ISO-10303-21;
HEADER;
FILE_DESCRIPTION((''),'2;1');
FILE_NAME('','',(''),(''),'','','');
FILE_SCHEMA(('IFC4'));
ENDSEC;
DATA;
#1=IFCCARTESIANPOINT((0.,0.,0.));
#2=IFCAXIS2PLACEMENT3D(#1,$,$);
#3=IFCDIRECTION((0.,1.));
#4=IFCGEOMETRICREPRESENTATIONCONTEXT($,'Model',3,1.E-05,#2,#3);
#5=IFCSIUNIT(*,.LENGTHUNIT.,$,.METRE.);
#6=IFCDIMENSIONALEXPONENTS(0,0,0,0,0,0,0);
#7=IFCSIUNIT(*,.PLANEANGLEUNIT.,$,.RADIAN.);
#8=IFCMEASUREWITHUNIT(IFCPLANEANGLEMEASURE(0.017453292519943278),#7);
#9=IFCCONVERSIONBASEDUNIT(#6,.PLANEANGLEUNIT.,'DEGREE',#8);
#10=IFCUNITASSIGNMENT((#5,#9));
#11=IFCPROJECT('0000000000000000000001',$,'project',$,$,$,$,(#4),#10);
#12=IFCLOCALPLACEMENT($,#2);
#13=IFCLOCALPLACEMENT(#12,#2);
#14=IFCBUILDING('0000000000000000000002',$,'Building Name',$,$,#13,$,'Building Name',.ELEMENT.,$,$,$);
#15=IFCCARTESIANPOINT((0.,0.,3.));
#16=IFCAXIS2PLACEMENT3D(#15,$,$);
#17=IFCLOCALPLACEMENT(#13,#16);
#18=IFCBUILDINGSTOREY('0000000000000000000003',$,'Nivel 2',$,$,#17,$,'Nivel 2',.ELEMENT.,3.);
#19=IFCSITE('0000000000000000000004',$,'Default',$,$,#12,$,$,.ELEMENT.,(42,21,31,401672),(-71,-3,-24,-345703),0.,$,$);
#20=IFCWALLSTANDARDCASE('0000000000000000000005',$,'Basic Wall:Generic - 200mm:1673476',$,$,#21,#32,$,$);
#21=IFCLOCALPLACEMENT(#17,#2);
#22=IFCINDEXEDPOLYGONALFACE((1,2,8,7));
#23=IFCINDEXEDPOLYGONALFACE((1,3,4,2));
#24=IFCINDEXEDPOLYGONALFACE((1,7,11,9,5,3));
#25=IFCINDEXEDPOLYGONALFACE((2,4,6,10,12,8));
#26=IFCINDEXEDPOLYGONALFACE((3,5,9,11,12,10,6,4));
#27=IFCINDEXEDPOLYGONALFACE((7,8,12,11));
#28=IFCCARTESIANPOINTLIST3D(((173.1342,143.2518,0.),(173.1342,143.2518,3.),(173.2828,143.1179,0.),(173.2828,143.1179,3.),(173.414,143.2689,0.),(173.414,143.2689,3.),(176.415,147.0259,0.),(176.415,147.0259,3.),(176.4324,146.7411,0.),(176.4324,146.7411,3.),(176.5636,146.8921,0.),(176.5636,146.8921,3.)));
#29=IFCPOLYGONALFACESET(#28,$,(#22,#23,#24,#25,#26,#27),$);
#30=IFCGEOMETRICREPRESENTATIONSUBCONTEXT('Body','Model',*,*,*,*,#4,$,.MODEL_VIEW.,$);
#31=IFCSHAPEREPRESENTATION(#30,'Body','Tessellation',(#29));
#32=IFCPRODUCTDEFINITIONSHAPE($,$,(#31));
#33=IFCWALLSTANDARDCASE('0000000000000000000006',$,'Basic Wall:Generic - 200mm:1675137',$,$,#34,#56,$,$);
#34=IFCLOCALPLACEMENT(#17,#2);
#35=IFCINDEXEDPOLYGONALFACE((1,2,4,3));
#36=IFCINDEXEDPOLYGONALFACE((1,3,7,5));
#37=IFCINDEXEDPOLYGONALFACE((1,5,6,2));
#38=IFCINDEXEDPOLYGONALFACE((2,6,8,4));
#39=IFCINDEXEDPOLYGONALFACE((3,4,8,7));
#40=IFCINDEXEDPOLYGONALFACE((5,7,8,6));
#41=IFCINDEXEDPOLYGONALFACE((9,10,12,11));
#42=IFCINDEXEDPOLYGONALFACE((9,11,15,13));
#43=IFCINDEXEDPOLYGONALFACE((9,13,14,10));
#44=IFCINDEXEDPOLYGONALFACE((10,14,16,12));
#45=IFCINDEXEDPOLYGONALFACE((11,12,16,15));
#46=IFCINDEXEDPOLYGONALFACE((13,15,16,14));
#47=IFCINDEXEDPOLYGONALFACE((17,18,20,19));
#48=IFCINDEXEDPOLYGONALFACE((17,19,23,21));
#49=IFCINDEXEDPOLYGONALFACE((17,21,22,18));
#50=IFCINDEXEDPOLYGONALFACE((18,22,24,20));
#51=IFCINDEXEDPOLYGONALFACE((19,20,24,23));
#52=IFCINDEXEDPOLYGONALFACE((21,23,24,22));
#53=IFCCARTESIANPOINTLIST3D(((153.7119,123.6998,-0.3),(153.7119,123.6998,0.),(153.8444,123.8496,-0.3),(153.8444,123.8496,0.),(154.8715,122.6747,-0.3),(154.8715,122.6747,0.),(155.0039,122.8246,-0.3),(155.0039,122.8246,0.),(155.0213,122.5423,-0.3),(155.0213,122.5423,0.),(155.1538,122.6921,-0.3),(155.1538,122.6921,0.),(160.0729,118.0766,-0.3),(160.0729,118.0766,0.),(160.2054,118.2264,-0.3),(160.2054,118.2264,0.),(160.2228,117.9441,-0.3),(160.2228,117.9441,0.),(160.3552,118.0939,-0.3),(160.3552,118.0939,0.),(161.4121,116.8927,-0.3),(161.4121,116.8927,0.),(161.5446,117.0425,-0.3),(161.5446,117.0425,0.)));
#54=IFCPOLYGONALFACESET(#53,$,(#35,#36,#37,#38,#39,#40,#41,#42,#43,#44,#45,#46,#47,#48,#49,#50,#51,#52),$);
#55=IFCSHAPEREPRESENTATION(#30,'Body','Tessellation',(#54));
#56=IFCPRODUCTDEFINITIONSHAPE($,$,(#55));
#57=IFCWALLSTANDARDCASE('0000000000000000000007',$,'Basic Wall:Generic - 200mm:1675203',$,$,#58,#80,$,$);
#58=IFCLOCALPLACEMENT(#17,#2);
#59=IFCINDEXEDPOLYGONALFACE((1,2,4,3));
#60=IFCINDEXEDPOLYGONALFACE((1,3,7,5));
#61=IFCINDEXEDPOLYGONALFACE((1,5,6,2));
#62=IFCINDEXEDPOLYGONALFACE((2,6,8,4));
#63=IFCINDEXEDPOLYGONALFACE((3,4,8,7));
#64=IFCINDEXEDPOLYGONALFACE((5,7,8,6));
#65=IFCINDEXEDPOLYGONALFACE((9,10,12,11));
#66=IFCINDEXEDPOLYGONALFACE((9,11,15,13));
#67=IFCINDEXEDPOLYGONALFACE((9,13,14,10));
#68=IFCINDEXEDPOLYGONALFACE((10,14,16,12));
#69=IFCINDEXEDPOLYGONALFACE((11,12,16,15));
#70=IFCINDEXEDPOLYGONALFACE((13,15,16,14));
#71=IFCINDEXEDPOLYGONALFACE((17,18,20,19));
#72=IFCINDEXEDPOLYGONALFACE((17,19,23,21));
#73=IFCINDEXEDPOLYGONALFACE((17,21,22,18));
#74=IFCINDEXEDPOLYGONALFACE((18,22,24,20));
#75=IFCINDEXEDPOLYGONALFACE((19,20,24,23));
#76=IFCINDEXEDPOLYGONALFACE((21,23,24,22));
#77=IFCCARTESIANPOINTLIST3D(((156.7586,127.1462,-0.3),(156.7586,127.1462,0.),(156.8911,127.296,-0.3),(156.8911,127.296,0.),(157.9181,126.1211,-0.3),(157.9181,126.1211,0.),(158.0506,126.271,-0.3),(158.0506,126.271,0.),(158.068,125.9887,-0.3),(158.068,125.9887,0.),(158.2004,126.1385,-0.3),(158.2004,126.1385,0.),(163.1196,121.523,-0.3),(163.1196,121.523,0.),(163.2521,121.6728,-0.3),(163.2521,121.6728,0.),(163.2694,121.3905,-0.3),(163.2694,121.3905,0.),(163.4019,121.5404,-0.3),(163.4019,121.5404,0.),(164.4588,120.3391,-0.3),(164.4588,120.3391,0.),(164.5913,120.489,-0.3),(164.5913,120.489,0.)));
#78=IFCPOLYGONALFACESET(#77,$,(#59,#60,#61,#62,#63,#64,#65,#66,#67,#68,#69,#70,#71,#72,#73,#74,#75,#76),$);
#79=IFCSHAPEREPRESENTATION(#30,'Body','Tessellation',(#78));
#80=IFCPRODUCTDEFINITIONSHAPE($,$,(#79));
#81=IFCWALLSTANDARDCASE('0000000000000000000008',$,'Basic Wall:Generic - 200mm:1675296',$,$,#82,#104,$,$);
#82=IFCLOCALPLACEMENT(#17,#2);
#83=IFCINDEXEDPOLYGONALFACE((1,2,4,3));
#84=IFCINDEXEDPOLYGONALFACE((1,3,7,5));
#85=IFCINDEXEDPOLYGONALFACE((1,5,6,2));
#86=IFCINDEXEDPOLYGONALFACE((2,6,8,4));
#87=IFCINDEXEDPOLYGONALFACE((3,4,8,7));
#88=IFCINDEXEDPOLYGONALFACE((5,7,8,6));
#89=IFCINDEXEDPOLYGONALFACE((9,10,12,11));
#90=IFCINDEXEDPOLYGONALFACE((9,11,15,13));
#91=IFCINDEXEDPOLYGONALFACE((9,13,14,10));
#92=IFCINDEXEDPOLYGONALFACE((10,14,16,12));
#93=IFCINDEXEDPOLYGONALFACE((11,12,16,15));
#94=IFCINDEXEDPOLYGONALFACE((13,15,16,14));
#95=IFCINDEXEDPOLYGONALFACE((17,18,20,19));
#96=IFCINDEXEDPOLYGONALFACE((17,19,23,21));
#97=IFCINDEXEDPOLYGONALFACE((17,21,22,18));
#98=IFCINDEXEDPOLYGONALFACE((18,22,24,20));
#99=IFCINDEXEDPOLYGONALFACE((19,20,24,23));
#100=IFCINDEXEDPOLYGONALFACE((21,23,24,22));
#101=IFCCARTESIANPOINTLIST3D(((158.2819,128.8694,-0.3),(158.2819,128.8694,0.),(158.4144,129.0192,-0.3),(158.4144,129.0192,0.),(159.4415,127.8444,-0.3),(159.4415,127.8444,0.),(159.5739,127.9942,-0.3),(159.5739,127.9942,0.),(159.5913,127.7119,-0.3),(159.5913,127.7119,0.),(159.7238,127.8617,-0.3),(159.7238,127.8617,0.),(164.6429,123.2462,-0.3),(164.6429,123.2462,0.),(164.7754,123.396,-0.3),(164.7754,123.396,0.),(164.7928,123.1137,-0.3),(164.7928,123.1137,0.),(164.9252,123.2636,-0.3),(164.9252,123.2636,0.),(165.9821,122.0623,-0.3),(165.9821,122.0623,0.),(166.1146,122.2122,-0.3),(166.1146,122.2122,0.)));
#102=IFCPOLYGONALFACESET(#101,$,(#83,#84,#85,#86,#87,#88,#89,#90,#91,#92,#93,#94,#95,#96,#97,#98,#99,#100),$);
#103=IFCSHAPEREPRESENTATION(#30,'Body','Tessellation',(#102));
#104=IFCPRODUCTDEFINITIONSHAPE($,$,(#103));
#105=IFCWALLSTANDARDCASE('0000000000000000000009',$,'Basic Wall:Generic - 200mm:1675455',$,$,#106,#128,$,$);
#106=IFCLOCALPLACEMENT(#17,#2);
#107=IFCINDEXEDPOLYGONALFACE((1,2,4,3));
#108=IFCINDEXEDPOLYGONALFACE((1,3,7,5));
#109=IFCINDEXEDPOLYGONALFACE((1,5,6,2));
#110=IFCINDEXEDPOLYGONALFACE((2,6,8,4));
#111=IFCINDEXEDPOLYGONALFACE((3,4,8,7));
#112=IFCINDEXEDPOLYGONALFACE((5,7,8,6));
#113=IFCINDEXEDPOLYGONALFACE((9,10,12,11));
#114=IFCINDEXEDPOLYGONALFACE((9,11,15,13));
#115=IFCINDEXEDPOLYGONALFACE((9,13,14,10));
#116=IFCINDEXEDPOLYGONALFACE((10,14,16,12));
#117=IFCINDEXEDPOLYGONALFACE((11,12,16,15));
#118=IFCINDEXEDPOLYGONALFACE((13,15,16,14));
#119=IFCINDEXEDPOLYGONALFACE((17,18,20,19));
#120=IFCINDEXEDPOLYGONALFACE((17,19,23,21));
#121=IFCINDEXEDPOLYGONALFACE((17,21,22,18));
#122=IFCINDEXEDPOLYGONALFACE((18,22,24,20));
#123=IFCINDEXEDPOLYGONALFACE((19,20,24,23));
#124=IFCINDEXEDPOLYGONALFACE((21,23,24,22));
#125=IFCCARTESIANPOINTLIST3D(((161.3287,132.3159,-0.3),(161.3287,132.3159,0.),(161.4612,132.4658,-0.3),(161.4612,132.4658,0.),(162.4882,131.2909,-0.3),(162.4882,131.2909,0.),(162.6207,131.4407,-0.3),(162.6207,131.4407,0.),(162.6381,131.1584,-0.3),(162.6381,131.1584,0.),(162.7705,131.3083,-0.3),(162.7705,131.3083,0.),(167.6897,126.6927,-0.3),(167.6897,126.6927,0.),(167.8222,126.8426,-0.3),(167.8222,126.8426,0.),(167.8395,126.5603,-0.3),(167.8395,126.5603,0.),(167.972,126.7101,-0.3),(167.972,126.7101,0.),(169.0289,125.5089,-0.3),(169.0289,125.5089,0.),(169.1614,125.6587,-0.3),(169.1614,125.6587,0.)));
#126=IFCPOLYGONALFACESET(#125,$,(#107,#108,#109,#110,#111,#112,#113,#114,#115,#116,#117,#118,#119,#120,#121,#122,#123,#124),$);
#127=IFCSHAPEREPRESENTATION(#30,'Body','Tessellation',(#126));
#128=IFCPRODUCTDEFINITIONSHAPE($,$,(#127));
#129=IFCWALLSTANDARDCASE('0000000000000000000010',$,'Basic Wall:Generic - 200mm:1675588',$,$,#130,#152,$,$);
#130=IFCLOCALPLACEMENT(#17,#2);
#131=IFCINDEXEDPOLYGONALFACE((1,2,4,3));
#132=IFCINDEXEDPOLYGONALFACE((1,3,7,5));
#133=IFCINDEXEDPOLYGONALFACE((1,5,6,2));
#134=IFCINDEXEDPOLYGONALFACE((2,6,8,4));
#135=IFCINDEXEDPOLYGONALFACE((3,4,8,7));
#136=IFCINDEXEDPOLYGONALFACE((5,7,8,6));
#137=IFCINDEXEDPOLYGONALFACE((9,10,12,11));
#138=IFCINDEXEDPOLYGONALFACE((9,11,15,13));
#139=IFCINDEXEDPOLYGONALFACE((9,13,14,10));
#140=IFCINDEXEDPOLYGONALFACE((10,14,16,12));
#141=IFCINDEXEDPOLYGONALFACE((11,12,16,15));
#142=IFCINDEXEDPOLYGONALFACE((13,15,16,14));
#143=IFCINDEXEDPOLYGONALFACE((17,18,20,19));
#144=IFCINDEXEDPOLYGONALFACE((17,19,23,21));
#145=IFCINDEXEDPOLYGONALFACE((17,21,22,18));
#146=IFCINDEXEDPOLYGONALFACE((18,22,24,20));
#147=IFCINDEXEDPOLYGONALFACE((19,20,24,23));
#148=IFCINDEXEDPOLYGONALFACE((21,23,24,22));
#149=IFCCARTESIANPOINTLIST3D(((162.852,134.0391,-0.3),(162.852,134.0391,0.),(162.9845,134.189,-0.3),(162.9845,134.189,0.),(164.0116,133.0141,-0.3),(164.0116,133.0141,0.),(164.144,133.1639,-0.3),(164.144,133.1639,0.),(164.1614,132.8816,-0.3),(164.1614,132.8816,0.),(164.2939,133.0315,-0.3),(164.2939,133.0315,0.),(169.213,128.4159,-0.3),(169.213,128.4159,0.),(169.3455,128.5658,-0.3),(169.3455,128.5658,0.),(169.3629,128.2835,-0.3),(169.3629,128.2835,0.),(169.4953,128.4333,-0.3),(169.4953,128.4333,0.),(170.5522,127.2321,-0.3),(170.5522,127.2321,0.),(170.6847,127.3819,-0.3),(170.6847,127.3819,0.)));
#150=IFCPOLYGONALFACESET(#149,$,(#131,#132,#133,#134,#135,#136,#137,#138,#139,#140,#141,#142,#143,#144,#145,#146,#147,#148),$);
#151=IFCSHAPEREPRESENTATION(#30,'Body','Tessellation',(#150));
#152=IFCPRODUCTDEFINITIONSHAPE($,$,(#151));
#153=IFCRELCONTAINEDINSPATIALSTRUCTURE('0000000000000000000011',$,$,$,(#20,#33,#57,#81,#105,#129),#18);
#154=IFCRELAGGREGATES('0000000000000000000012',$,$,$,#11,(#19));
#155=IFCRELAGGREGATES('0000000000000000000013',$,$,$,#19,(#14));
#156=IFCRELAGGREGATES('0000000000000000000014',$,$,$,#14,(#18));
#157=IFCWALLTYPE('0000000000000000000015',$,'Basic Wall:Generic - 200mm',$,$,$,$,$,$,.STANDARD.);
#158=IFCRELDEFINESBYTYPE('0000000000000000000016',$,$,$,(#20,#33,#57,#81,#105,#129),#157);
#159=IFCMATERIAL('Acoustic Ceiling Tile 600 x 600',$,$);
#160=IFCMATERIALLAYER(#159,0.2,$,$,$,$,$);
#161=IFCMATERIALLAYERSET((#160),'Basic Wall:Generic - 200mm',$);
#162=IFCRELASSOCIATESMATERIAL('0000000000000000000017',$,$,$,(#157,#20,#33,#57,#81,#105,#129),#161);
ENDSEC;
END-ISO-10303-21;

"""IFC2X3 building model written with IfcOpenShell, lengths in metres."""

from ifc_helpers import new_model, entity, si_unit, converted_unit, direction, frame, frame_2d, origin, origin_2d_with_axis, place, context, subcontext, project, spatial, polyline, rectangle, outline, extrude, material, layer, layer_set, layer_usage, type_object, element, save


model = new_model("IFC2X3")

# Units and contexts
model_context = context("Model", 3, precision=1e-05, world=origin(), true_north=direction((0.0, 1.0)))
body_context = subcontext(model_context, "Body", "Model", "MODEL_VIEW")
ifc_project = project(units=[si_unit("LENGTHUNIT", "METRE"), converted_unit("PLANEANGLEUNIT", "DEGREE", entity("IfcPlaneAngleMeasure", 0.017453292519943278), si_unit("PLANEANGLEUNIT", "RADIAN"), dimensions=[0, 0, 0, 0, 0, 0, 0])], contexts=[model_context])

# Site, building, storey
site_placement = place(None, origin())
site = spatial("IfcSite", under=ifc_project, at=site_placement, Name="Default", CompositionType="ELEMENT", RefLatitude=(42, 21, 31, 401672), RefLongitude=(-71, -3, -24, -345703), RefElevation=0.0)
building_placement = place(site_placement, origin())
building = spatial("IfcBuilding", under=site, at=building_placement, Name="Building Name", LongName="Building Name", CompositionType="ELEMENT")
storey_placement = place(building_placement, frame((0.0, 0.0, 3.0)))
storey = spatial("IfcBuildingStorey", under=building, at=storey_placement, Name="Nivel 2", LongName="Nivel 2", CompositionType="ELEMENT", Elevation=3.0)

# Wall
ifc_material_1 = material(Name="Acoustic Ceiling Tile 600 x 600")
ifc_layer = layer(ifc_material_1, 0.2)
ifc_layer_set = layer_set([ifc_layer], Name="Basic Wall:Generic - 200mm")
ifc_layer_usage_1 = layer_usage(ifc_layer_set, "AXIS2", "NEGATIVE", 0.1)
wall_type_1 = type_object("IfcWallType", Name="Basic Wall:Generic - 200mm", PredefinedType="STANDARD", material=ifc_layer_set)
wall_1_placement = place(storey_placement, frame((173.2073, 143.1835, 0.0), z_axis=(0.0, 0.0, 1.0), x_axis=(0.656059, 0.75471, 0.0)))
element("IfcWallStandardCase", 1, at=wall_1_placement, inside=storey, type_object=wall_type_1, material=ifc_layer_usage_1, Name="Basic Wall:Generic - 200mm:1673476", context=body_context, shape_type="SweptSolid", body=[
    extrude(outline(polyline([(5.0008, -0.1), (5.0043, 0.1), (0.0035, 0.1), (0.0, -0.1), (0.2, -0.1), (4.8007, -0.1), (5.0008, -0.1)])), origin(), (0.0, 0.0, 1.0), 3.0),
])

# Walls, openings
ifc_layer_usage_2 = layer_usage(ifc_layer_set, "AXIS2", "NEGATIVE", 0.1)
wall_2_placement = place(storey_placement, frame((161.4784, 116.9676, -0.3), z_axis=(0.0, 0.0, 1.0), x_axis=(-0.749221, 0.66232, 0.0)))
wall_2 = element("IfcWallStandardCase", 2, at=wall_2_placement, inside=storey, type_object=wall_type_1, material=ifc_layer_usage_2, Name="Basic Wall:Generic - 200mm:1675137", context=body_context, shape_type="SweptSolid", body=[
    extrude(rectangle(XDim=10.2776, YDim=0.2, at=frame_2d((5.1388, 0.0), x_axis=(-1.0, 0.0))), origin(), (0.0, 0.0, 1.0), 0.3),
])
opening_1_placement = place(storey_placement, frame((161.4784, 116.9676, -0.3), z_axis=(0.0, 0.0, 1.0), x_axis=(-0.749221, 0.66232, 0.0)))
element("IfcOpeningElement", 3, at=opening_1_placement, cuts=wall_2, ObjectType="Opening", context=body_context, shape_type="SweptSolid", body=[
    extrude(rectangle(XDim=0.3, YDim=0.2, at=frame_2d((0.0, 0.0), x_axis=(1.0, 0.0))), frame((1.5874, 0.0, 0.15), z_axis=(1.0, 0.0, 0.0), x_axis=(0.0, 0.0, -1.0)), (0.0, 0.0, 1.0), 0.2),
])
opening_2_placement = place(storey_placement, frame((161.4784, 116.9676, -0.3), z_axis=(0.0, 0.0, 1.0), x_axis=(-0.749221, 0.66232, 0.0)))
element("IfcOpeningElement", 4, at=opening_2_placement, cuts=wall_2, ObjectType="Opening", context=body_context, shape_type="SweptSolid", body=[
    extrude(rectangle(XDim=0.3, YDim=0.2, at=frame_2d((0.0, 0.0), x_axis=(1.0, 0.0))), frame((8.53, 0.0, 0.15), z_axis=(1.0, 0.0, 0.0), x_axis=(0.0, 0.0, -1.0)), (0.0, 0.0, 1.0), 0.2),
])
ifc_layer_usage_3 = layer_usage(ifc_layer_set, "AXIS2", "NEGATIVE", 0.1)
wall_3_placement = place(storey_placement, frame((164.525, 120.414, -0.3), z_axis=(0.0, 0.0, 1.0), x_axis=(-0.749221, 0.66232, 0.0)))
wall_3 = element("IfcWallStandardCase", 5, at=wall_3_placement, inside=storey, type_object=wall_type_1, material=ifc_layer_usage_3, Name="Basic Wall:Generic - 200mm:1675203", context=body_context, shape_type="SweptSolid", body=[
    extrude(rectangle(XDim=10.2776, YDim=0.2, at=frame_2d((5.1388, 0.0), x_axis=(-1.0, 0.0))), origin(), (0.0, 0.0, 1.0), 0.3),
])
opening_3_placement = place(storey_placement, frame((164.525, 120.414, -0.3), z_axis=(0.0, 0.0, 1.0), x_axis=(-0.749221, 0.66232, 0.0)))
element("IfcOpeningElement", 6, at=opening_3_placement, cuts=wall_3, ObjectType="Opening", context=body_context, shape_type="SweptSolid", body=[
    extrude(rectangle(XDim=0.3, YDim=0.2, at=frame_2d((0.0, 0.0), x_axis=(1.0, 0.0))), frame((1.5874, 0.0, 0.15), z_axis=(1.0, 0.0, 0.0), x_axis=(0.0, 0.0, -1.0)), (0.0, 0.0, 1.0), 0.2),
])
opening_4_placement = place(storey_placement, frame((164.525, 120.414, -0.3), z_axis=(0.0, 0.0, 1.0), x_axis=(-0.749221, 0.66232, 0.0)))
element("IfcOpeningElement", 7, at=opening_4_placement, cuts=wall_3, ObjectType="Opening", context=body_context, shape_type="SweptSolid", body=[
    extrude(rectangle(XDim=0.3, YDim=0.2, at=frame_2d((0.0, 0.0), x_axis=(1.0, 0.0))), frame((8.53, 0.0, 0.15), z_axis=(1.0, 0.0, 0.0), x_axis=(0.0, 0.0, -1.0)), (0.0, 0.0, 1.0), 0.2),
])
ifc_layer_usage_4 = layer_usage(ifc_layer_set, "AXIS2", "NEGATIVE", 0.1)
wall_4_placement = place(storey_placement, frame((166.0484, 122.1373, -0.3), z_axis=(0.0, 0.0, 1.0), x_axis=(-0.749221, 0.66232, 0.0)))
wall_4 = element("IfcWallStandardCase", 8, at=wall_4_placement, inside=storey, type_object=wall_type_1, material=ifc_layer_usage_4, Name="Basic Wall:Generic - 200mm:1675296", context=body_context, shape_type="SweptSolid", body=[
    extrude(rectangle(XDim=10.2776, YDim=0.2, at=frame_2d((5.1388, 0.0), x_axis=(-1.0, 0.0))), origin(), (0.0, 0.0, 1.0), 0.3),
])
opening_5_placement = place(storey_placement, frame((166.0484, 122.1373, -0.3), z_axis=(0.0, 0.0, 1.0), x_axis=(-0.749221, 0.66232, 0.0)))
element("IfcOpeningElement", 9, at=opening_5_placement, cuts=wall_4, ObjectType="Opening", context=body_context, shape_type="SweptSolid", body=[
    extrude(rectangle(XDim=0.3, YDim=0.2, at=frame_2d((0.0, 0.0), x_axis=(1.0, 0.0))), frame((1.5874, 0.0, 0.15), z_axis=(1.0, 0.0, 0.0), x_axis=(0.0, 0.0, -1.0)), (0.0, 0.0, 1.0), 0.2),
])
opening_6_placement = place(storey_placement, frame((166.0484, 122.1373, -0.3), z_axis=(0.0, 0.0, 1.0), x_axis=(-0.749221, 0.66232, 0.0)))
element("IfcOpeningElement", 10, at=opening_6_placement, cuts=wall_4, ObjectType="Opening", context=body_context, shape_type="SweptSolid", body=[
    extrude(rectangle(XDim=0.3, YDim=0.2, at=origin_2d_with_axis()), frame((8.53, 0.0, 0.15), z_axis=(1.0, 0.0, 0.0), x_axis=(0.0, 0.0, -1.0)), (0.0, 0.0, 1.0), 0.2),
])
ifc_layer_usage_5 = layer_usage(ifc_layer_set, "AXIS2", "NEGATIVE", 0.1)
wall_5_placement = place(storey_placement, frame((169.0951, 125.5838, -0.3), z_axis=(0.0, 0.0, 1.0), x_axis=(-0.749221, 0.66232, 0.0)))
wall_5 = element("IfcWallStandardCase", 11, at=wall_5_placement, inside=storey, type_object=wall_type_1, material=ifc_layer_usage_5, Name="Basic Wall:Generic - 200mm:1675455", context=body_context, shape_type="SweptSolid", body=[
    extrude(rectangle(XDim=10.2776, YDim=0.2, at=frame_2d((5.1388, 0.0), x_axis=(-1.0, 0.0))), origin(), (0.0, 0.0, 1.0), 0.3),
])
opening_7_placement = place(storey_placement, frame((169.0951, 125.5838, -0.3), z_axis=(0.0, 0.0, 1.0), x_axis=(-0.749221, 0.66232, 0.0)))
element("IfcOpeningElement", 12, at=opening_7_placement, cuts=wall_5, ObjectType="Opening", context=body_context, shape_type="SweptSolid", body=[
    extrude(rectangle(XDim=0.3, YDim=0.2, at=frame_2d((0.0, 0.0), x_axis=(1.0, 0.0))), frame((1.5874, 0.0, 0.15), z_axis=(1.0, 0.0, 0.0), x_axis=(0.0, 0.0, -1.0)), (0.0, 0.0, 1.0), 0.2),
])
opening_8_placement = place(storey_placement, frame((169.0951, 125.5838, -0.3), z_axis=(0.0, 0.0, 1.0), x_axis=(-0.749221, 0.66232, 0.0)))
element("IfcOpeningElement", 13, at=opening_8_placement, cuts=wall_5, ObjectType="Opening", context=body_context, shape_type="SweptSolid", body=[
    extrude(rectangle(XDim=0.3, YDim=0.2, at=frame_2d((0.0, 0.0), x_axis=(1.0, 0.0))), frame((8.53, 0.0, 0.15), z_axis=(1.0, 0.0, 0.0), x_axis=(0.0, 0.0, -1.0)), (0.0, 0.0, 1.0), 0.2),
])
ifc_layer_usage_6 = layer_usage(ifc_layer_set, "AXIS2", "NEGATIVE", 0.1)
wall_6_placement = place(storey_placement, frame((170.6185, 127.307, -0.3), z_axis=(0.0, 0.0, 1.0), x_axis=(-0.749221, 0.66232, 0.0)))
wall_6 = element("IfcWallStandardCase", 14, at=wall_6_placement, inside=storey, type_object=wall_type_1, material=ifc_layer_usage_6, Name="Basic Wall:Generic - 200mm:1675588", context=body_context, shape_type="SweptSolid", body=[
    extrude(rectangle(XDim=10.2776, YDim=0.2, at=frame_2d((5.1388, 0.0), x_axis=(-1.0, 0.0))), origin(), (0.0, 0.0, 1.0), 0.3),
])
opening_9_placement = place(storey_placement, frame((170.6185, 127.307, -0.3), z_axis=(0.0, 0.0, 1.0), x_axis=(-0.749221, 0.66232, 0.0)))
element("IfcOpeningElement", 15, at=opening_9_placement, cuts=wall_6, ObjectType="Opening", context=body_context, shape_type="SweptSolid", body=[
    extrude(rectangle(XDim=0.3, YDim=0.2, at=origin_2d_with_axis()), frame((1.7874, 0.0, 0.15), z_axis=(-1.0, 0.0, 0.0), x_axis=(0.0, 0.0, 1.0)), (0.0, 0.0, 1.0), 0.2),
])
opening_10_placement = place(storey_placement, frame((170.6185, 127.307, -0.3), z_axis=(0.0, 0.0, 1.0), x_axis=(-0.749221, 0.66232, 0.0)))
element("IfcOpeningElement", 16, at=opening_10_placement, cuts=wall_6, ObjectType="Opening", context=body_context, shape_type="SweptSolid", body=[
    extrude(rectangle(XDim=0.3, YDim=0.2, at=origin_2d_with_axis()), frame((8.73, 0.0, 0.15), z_axis=(-1.0, 0.0, 0.0), x_axis=(0.0, 0.0, 1.0)), (0.0, 0.0, 1.0), 0.2),
])

save(model, "model.ifc")
